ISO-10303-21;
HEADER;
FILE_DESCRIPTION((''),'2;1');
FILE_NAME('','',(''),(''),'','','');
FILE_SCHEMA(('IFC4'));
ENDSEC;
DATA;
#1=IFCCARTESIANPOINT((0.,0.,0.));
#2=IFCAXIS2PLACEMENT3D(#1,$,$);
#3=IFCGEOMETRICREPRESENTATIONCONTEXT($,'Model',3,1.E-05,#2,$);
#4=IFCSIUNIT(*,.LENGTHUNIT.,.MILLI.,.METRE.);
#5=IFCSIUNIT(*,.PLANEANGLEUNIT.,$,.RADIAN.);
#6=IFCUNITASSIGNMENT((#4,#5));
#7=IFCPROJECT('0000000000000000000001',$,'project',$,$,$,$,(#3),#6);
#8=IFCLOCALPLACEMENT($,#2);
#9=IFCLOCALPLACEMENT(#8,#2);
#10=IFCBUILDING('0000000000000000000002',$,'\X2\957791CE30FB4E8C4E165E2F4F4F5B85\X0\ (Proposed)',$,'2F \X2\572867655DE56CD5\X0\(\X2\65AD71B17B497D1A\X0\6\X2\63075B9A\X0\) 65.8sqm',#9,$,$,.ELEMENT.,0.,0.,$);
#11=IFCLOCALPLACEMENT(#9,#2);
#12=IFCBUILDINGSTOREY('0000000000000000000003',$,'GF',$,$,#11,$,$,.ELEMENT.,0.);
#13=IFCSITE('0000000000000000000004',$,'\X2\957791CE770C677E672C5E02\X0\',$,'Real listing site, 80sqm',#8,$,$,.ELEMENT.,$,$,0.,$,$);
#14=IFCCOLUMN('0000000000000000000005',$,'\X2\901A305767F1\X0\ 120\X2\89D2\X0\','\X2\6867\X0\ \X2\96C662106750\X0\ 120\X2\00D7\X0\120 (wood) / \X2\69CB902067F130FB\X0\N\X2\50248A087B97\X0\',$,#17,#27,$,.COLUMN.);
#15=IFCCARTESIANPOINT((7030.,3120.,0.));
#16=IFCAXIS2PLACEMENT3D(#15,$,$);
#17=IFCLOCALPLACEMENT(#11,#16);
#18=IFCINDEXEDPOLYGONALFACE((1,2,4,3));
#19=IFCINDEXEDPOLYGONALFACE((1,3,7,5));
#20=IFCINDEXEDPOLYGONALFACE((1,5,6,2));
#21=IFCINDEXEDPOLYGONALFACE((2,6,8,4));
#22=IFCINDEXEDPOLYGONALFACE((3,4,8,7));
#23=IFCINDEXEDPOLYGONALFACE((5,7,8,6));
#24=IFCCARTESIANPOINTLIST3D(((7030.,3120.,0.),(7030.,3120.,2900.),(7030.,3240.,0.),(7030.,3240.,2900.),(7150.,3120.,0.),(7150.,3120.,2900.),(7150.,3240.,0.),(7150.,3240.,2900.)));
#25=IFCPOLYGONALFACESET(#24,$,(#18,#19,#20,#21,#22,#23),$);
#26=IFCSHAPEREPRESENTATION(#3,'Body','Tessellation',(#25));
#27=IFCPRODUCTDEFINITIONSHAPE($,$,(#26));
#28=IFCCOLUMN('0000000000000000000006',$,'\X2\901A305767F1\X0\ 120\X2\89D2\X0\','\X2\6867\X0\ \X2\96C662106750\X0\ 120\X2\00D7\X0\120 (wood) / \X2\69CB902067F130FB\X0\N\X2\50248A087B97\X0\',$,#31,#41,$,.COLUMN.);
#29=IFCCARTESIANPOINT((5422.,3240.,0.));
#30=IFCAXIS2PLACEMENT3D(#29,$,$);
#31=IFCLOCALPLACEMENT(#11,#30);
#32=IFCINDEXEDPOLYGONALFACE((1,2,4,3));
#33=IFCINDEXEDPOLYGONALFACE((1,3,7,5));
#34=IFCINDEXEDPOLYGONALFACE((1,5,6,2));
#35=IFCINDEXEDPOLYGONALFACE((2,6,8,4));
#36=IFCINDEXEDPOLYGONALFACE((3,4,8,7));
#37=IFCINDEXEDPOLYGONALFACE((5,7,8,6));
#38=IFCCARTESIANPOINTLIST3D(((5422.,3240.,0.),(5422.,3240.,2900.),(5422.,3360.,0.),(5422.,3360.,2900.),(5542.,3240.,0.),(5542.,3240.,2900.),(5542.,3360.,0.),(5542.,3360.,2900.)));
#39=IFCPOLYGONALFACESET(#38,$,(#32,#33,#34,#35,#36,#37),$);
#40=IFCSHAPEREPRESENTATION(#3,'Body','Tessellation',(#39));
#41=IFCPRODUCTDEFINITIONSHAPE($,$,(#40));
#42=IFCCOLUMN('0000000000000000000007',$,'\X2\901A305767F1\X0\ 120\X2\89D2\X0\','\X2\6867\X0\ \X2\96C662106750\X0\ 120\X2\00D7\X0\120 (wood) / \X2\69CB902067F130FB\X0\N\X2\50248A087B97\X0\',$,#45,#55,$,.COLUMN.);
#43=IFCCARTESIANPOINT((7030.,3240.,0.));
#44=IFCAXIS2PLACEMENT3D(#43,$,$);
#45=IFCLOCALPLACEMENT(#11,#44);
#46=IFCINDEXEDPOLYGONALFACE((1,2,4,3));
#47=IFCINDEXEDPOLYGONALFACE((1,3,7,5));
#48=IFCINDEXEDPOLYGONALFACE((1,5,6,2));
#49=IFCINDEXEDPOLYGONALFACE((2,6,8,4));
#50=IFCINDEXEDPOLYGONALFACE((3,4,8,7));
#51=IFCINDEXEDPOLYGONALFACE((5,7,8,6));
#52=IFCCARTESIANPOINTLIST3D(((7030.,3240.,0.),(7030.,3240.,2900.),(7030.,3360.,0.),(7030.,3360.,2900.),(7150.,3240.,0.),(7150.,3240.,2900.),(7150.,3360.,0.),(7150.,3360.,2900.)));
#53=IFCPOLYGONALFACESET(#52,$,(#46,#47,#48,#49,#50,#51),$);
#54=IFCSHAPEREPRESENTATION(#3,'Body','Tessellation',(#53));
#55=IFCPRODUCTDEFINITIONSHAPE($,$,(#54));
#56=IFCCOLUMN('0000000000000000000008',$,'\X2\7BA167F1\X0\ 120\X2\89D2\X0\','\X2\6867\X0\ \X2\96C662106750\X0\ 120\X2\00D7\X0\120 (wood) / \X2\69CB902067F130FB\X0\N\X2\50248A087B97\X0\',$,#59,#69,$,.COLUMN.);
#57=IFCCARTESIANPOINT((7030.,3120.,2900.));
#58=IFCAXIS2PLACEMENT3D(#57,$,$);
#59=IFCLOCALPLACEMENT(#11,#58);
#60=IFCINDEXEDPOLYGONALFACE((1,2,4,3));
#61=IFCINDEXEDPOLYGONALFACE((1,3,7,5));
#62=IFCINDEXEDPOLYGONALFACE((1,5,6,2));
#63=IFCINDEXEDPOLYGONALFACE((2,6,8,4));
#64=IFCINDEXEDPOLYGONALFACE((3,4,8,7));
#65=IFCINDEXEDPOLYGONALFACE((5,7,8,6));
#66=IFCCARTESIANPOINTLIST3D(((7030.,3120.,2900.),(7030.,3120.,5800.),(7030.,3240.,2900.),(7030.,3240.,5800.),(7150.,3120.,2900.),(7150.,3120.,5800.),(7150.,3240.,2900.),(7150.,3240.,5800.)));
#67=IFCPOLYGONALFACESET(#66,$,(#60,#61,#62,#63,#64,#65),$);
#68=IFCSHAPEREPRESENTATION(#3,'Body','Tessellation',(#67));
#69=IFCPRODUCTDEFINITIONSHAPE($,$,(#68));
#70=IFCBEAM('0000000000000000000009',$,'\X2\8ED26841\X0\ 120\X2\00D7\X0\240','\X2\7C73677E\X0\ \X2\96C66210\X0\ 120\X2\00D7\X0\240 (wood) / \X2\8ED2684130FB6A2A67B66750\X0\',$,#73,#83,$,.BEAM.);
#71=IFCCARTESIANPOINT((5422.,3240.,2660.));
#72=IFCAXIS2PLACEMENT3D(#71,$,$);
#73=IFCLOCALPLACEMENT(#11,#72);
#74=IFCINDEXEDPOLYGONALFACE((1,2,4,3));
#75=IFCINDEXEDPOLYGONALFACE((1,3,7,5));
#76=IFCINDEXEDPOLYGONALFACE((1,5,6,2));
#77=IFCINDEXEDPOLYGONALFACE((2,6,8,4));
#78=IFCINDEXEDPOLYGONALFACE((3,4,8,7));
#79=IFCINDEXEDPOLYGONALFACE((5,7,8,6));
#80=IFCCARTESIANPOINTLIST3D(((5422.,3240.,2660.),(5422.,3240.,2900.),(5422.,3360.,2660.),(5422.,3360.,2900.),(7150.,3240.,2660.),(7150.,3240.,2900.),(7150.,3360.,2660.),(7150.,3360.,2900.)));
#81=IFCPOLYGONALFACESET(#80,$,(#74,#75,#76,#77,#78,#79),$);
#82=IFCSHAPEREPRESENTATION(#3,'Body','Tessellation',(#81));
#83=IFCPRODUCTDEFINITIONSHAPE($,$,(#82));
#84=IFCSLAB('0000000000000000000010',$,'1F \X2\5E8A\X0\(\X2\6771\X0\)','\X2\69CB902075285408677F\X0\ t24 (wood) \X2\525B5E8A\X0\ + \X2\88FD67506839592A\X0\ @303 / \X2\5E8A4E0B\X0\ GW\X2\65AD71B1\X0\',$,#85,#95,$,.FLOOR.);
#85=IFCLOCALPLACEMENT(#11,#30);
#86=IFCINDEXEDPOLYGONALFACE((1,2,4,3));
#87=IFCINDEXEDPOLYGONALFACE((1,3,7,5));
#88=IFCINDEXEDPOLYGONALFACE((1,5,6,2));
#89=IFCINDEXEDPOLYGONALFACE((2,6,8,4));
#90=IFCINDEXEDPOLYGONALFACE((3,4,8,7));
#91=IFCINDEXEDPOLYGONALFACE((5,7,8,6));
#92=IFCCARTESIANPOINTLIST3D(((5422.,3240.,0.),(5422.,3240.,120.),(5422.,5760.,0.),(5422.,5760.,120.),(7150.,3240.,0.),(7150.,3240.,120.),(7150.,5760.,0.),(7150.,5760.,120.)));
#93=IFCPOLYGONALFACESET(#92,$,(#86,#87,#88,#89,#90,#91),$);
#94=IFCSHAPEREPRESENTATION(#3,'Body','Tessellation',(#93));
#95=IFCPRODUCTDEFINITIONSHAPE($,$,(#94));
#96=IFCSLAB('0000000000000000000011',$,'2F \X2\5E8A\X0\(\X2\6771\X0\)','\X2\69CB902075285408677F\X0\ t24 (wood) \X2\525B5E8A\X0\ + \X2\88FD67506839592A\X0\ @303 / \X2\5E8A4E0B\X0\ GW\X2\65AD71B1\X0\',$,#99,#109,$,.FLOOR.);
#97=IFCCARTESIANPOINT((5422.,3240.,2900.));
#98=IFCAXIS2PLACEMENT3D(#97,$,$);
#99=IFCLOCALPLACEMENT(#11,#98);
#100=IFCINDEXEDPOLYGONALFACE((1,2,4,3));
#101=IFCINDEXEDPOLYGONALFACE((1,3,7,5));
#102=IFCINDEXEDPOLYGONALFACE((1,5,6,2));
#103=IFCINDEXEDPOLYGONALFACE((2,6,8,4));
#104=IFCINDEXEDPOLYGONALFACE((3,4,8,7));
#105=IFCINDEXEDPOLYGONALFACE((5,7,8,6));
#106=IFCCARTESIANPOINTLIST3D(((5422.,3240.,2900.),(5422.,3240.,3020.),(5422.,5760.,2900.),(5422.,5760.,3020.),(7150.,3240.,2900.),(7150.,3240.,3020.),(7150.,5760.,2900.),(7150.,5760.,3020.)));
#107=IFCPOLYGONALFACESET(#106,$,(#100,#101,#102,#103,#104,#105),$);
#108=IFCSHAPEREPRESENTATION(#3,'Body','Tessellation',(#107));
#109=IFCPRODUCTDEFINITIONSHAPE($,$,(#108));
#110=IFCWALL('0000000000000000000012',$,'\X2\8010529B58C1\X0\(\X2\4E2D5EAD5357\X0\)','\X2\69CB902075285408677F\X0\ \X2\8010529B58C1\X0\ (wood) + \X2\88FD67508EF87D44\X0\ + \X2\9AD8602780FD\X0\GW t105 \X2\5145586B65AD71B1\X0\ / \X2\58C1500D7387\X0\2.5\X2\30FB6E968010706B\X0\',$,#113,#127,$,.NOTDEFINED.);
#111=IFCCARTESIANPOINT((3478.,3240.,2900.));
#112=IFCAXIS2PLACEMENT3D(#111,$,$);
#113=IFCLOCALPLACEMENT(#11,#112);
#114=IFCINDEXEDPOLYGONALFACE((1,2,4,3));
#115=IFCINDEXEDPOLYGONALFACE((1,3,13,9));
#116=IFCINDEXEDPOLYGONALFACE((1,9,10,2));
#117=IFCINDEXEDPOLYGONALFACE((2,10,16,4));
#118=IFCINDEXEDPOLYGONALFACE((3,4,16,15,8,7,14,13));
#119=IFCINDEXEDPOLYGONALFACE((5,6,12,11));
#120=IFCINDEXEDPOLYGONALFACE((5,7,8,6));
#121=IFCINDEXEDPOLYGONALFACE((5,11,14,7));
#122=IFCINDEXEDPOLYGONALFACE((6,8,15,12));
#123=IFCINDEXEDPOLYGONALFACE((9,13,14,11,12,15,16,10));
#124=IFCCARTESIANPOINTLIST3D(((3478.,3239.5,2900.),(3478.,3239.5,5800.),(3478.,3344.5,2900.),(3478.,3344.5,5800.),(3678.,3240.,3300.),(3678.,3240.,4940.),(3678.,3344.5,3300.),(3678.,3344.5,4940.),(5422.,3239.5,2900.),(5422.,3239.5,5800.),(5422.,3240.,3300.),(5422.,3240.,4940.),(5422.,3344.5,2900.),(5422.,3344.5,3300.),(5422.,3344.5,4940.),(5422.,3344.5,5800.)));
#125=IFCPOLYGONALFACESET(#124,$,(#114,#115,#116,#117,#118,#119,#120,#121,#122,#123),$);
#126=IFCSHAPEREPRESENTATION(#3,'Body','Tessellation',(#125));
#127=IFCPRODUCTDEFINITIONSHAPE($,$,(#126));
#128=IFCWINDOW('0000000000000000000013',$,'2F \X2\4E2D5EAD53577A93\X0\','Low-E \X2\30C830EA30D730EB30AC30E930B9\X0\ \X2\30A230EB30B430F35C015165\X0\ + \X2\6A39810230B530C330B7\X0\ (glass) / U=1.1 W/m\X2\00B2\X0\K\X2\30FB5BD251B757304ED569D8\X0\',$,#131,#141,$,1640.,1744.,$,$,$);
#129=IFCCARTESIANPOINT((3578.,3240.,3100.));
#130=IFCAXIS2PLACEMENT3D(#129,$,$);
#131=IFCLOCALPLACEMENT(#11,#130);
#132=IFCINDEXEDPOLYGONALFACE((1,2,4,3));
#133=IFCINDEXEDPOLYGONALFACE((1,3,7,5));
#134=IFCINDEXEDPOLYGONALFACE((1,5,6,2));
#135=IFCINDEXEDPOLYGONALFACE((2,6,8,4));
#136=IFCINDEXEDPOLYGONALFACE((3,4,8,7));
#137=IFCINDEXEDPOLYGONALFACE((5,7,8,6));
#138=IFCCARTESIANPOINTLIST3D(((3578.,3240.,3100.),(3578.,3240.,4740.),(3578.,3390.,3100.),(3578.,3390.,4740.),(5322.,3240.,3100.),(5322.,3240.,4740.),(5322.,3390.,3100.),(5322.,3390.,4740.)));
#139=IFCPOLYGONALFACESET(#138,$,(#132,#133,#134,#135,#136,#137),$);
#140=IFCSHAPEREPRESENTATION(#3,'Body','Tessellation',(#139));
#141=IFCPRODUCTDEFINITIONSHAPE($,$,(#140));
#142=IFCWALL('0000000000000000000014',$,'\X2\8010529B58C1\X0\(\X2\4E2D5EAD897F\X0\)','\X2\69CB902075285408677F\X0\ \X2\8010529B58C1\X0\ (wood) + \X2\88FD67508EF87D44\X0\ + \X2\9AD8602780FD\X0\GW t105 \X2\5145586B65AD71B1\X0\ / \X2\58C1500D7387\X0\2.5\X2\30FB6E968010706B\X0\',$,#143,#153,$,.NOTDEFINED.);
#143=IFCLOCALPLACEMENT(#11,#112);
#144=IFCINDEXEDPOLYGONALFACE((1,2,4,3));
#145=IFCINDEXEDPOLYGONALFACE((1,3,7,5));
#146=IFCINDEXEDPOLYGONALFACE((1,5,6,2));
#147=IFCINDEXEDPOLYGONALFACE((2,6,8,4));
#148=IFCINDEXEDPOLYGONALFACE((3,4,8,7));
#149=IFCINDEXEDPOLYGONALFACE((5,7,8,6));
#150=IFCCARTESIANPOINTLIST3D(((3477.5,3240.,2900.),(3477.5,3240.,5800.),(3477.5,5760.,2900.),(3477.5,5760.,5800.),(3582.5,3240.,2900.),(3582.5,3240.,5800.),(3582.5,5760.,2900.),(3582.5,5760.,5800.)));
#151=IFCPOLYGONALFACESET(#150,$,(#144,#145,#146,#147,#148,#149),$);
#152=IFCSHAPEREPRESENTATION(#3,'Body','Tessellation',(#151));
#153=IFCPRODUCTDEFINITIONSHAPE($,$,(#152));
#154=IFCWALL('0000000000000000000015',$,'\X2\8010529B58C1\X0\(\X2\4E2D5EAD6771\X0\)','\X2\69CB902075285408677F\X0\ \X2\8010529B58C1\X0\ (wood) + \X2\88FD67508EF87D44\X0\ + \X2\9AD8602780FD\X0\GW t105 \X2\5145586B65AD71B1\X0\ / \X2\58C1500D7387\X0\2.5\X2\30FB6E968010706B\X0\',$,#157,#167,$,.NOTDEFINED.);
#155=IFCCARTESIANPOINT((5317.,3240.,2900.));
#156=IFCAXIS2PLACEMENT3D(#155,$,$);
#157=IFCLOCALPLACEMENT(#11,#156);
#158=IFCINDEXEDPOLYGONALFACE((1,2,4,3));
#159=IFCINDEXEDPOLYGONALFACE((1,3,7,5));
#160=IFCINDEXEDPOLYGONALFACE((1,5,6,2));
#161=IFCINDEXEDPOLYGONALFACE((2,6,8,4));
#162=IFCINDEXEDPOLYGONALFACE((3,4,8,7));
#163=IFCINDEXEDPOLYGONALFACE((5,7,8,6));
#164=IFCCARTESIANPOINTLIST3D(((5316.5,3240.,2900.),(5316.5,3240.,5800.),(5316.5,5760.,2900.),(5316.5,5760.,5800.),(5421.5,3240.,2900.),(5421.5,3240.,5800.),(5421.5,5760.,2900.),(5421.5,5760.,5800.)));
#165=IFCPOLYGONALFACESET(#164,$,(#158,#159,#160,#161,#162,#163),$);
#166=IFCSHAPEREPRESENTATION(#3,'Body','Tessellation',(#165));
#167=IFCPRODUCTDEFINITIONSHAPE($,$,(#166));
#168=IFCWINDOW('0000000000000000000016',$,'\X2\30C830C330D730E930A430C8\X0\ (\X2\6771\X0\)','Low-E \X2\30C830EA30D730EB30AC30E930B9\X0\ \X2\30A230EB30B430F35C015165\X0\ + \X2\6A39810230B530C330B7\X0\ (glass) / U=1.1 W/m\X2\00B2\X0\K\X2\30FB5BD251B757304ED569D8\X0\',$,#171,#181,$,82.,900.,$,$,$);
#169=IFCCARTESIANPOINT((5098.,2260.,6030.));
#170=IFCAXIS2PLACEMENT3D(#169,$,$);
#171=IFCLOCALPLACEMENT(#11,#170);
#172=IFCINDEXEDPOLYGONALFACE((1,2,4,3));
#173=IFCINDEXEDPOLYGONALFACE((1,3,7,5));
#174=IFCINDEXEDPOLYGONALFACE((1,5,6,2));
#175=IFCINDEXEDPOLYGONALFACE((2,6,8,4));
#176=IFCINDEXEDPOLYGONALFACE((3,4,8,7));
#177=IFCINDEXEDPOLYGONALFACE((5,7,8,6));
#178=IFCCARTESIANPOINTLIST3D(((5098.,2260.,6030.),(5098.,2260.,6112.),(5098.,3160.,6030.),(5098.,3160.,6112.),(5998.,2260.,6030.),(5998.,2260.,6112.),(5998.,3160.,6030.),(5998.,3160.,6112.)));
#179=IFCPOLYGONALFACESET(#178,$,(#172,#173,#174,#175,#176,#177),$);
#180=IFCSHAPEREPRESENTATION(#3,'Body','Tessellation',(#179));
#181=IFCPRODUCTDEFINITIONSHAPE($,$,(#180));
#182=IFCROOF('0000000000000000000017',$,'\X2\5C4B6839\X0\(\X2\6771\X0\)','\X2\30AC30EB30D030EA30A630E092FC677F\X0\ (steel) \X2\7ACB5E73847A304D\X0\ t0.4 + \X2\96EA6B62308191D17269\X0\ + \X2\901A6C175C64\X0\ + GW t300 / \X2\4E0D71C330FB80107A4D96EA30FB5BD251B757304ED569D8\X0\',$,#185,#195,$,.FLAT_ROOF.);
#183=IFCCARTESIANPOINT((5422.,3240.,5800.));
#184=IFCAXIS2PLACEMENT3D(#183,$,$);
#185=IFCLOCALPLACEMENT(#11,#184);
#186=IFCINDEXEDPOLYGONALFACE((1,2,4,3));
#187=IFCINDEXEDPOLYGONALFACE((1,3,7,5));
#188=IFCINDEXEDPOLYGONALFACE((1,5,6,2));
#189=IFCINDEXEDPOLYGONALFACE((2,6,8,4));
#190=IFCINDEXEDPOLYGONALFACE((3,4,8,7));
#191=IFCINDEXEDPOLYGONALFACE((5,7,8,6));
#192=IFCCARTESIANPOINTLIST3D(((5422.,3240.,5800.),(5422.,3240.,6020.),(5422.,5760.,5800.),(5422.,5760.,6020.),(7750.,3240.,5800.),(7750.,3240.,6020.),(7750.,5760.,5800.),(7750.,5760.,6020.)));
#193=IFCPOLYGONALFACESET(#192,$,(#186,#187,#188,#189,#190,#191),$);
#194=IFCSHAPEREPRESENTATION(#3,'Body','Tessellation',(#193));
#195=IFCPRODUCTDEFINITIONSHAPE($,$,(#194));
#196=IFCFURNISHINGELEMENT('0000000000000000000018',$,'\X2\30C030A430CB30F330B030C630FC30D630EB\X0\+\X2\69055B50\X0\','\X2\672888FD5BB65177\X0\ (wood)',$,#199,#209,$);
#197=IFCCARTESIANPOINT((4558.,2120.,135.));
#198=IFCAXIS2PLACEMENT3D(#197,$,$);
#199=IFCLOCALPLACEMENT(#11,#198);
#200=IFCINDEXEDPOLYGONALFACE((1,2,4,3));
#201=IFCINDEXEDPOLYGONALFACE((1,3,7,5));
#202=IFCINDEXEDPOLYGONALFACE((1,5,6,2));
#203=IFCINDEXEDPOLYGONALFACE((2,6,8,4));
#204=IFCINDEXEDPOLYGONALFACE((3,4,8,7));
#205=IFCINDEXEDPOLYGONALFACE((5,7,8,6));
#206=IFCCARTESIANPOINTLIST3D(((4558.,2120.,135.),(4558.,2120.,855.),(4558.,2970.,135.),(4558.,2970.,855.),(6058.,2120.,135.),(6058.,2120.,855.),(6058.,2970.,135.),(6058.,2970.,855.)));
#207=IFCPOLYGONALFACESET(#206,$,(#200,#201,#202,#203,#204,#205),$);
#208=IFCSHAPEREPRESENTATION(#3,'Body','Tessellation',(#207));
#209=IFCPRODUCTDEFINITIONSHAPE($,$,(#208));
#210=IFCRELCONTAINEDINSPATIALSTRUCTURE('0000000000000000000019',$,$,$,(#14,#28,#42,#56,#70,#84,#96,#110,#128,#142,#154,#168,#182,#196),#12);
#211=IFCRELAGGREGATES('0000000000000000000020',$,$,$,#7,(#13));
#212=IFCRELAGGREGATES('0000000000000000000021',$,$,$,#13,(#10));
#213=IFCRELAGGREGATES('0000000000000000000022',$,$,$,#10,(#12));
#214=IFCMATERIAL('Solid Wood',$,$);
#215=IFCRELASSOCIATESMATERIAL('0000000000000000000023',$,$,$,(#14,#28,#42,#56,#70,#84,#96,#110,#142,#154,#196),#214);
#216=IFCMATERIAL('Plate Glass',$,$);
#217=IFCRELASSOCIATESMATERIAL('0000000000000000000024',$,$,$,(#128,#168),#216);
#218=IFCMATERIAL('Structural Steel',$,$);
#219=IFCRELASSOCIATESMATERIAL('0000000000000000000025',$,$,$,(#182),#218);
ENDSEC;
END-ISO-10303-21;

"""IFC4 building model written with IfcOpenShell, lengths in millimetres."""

from ifc_helpers import new_model, si_unit, frame, frame_2d, origin, place, context, project, spatial, rectangle, extrude, material, element, fill, save


model = new_model("IFC4")

# Units and contexts
model_context = context("Model", 3, precision=1e-05, world=origin())
ifc_project = project(units=[si_unit("LENGTHUNIT", "METRE", prefix="MILLI"), si_unit("PLANEANGLEUNIT", "RADIAN")], contexts=[model_context])

# Site, building, storey
site_placement = place(None, origin())
site = spatial("IfcSite", under=ifc_project, at=site_placement, Name="長野県松本市", ObjectType="Real listing site, 80sqm", CompositionType="ELEMENT", RefElevation=0.0)
building_placement = place(site_placement, origin())
building = spatial("IfcBuilding", under=site, at=building_placement, Name="長野・二世帯住宅 (Proposed)", ObjectType="2F 在来工法(断熱等級6指定) 65.8sqm", CompositionType="ELEMENT", ElevationOfRefHeight=0.0, ElevationOfTerrain=0.0)
storey_placement = place(building_placement, origin())
storey = spatial("IfcBuildingStorey", under=building, at=storey_placement, Name="GF", CompositionType="ELEMENT", Elevation=0.0)

# Columns
ifc_material_1 = material(Name="Solid Wood")
column_1_placement = place(storey_placement, frame((7030.0, 3120.0, 0.0)))
element("IfcColumn", 1, at=column_1_placement, inside=storey, material=ifc_material_1, Name="通し柱 120角", Description="桧 集成材 120×120 (wood) / 構造柱・N値計算", PredefinedType="COLUMN", context=model_context, shape_type="SweptSolid", body=[
    extrude(rectangle(XDim=120.0, YDim=120.0, at=frame_2d((60.0, 60.0))), frame((7030.0, 3120.0, 0.0)), (0.0, 0.0, 1.0), 2900.0),
])
column_2_placement = place(storey_placement, frame((5422.0, 3240.0, 0.0)))
element("IfcColumn", 2, at=column_2_placement, inside=storey, material=ifc_material_1, Name="通し柱 120角", Description="桧 集成材 120×120 (wood) / 構造柱・N値計算", PredefinedType="COLUMN", context=model_context, shape_type="SweptSolid", body=[
    extrude(rectangle(XDim=120.0, YDim=120.0, at=frame_2d((60.0, 60.0))), frame((5422.0, 3240.0, 0.0)), (0.0, 0.0, 1.0), 2900.0),
])
column_3_placement = place(storey_placement, frame((7030.0, 3240.0, 0.0)))
element("IfcColumn", 3, at=column_3_placement, inside=storey, material=ifc_material_1, Name="通し柱 120角", Description="桧 集成材 120×120 (wood) / 構造柱・N値計算", PredefinedType="COLUMN", context=model_context, shape_type="SweptSolid", body=[
    extrude(rectangle(XDim=120.0, YDim=120.0, at=frame_2d((60.0, 60.0))), frame((7030.0, 3240.0, 0.0)), (0.0, 0.0, 1.0), 2900.0),
])
column_4_placement = place(storey_placement, frame((7030.0, 3120.0, 2900.0)))
element("IfcColumn", 4, at=column_4_placement, inside=storey, material=ifc_material_1, Name="管柱 120角", Description="桧 集成材 120×120 (wood) / 構造柱・N値計算", PredefinedType="COLUMN", context=model_context, shape_type="SweptSolid", body=[
    extrude(rectangle(XDim=120.0, YDim=120.0, at=frame_2d((60.0, 60.0))), frame((7030.0, 3120.0, 2900.0)), (0.0, 0.0, 1.0), 2900.0),
])

# Beam
beam_1_placement = place(storey_placement, frame((5422.0, 3240.0, 2660.0)))
element("IfcBeam", 5, at=beam_1_placement, inside=storey, material=ifc_material_1, Name="軒桁 120×240", Description="米松 集成 120×240 (wood) / 軒桁・横架材", PredefinedType="BEAM", context=model_context, shape_type="SweptSolid", body=[
    extrude(rectangle(XDim=1728.0, YDim=120.0, at=frame_2d((864.0, 60.0))), frame((5422.0, 3240.0, 2660.0)), (0.0, 0.0, 1.0), 240.0),
])

# Slabs
slab_1_placement = place(storey_placement, frame((5422.0, 3240.0, 0.0)))
element("IfcSlab", 6, at=slab_1_placement, inside=storey, material=ifc_material_1, Name="1F 床(東)", Description="構造用合板 t24 (wood) 剛床 + 製材根太 @303 / 床下 GW断熱", PredefinedType="FLOOR", context=model_context, shape_type="SweptSolid", body=[
    extrude(rectangle(XDim=1728.0, YDim=2520.0, at=frame_2d((864.0, 1260.0))), frame((5422.0, 3240.0, 0.0)), (0.0, 0.0, 1.0), 120.0),
])
slab_2_placement = place(storey_placement, frame((5422.0, 3240.0, 2900.0)))
element("IfcSlab", 7, at=slab_2_placement, inside=storey, material=ifc_material_1, Name="2F 床(東)", Description="構造用合板 t24 (wood) 剛床 + 製材根太 @303 / 床下 GW断熱", PredefinedType="FLOOR", context=model_context, shape_type="SweptSolid", body=[
    extrude(rectangle(XDim=1728.0, YDim=2520.0, at=frame_2d((864.0, 1260.0))), frame((5422.0, 3240.0, 2900.0)), (0.0, 0.0, 1.0), 120.0),
])

# Wall, opening, window
wall_1_placement = place(storey_placement, frame((3478.0, 3240.0, 2900.0)))
wall_1 = element("IfcWall", 8, at=wall_1_placement, inside=storey, material=ifc_material_1, Name="耐力壁(中庭南)", Description="構造用合板 耐力壁 (wood) + 製材軸組 + 高性能GW t105 充填断熱 / 壁倍率2.5・準耐火", PredefinedType="NOTDEFINED", context=model_context, shape_type="SweptSolid", body=[
    extrude(rectangle(XDim=1944.0, YDim=105.0, at=frame_2d((972.0, 52.0))), frame((3478.0, 3240.0, 2900.0)), (0.0, 0.0, 1.0), 2900.0),
])
opening_placement = place(storey_placement, frame((3578.0, 3240.0, 3100.0)))
opening = element("IfcOpeningElement", 9, at=opening_placement, cuts=wall_1, PredefinedType="NOTDEFINED", context=model_context, shape_type="SweptSolid", body=[
    extrude(rectangle(XDim=1744.0, YDim=150.0, at=frame_2d((872.0, 75.0))), frame((3578.0, 3240.0, 3100.0)), (0.0, 0.0, 1.0), 1640.0),
])
ifc_material_2 = material(Name="Plate Glass")
window_1_placement = place(storey_placement, frame((3578.0, 3240.0, 3100.0)))
window_1 = element("IfcWindow", 10, at=window_1_placement, inside=storey, material=ifc_material_2, Name="2F 中庭南窓", Description="Low-E トリプルガラス アルゴン封入 + 樹脂サッシ (glass) / U=1.1 W/m²K・寒冷地仕様", OverallHeight=1640.0, OverallWidth=1744.0, context=model_context, shape_type="SweptSolid", body=[
    extrude(rectangle(XDim=1744.0, YDim=150.0, at=frame_2d((872.0, 75.0))), frame((3578.0, 3240.0, 3100.0)), (0.0, 0.0, 1.0), 1640.0),
])
fill(opening, window_1)

# Walls
wall_2_placement = place(storey_placement, frame((3478.0, 3240.0, 2900.0)))
element("IfcWall", 11, at=wall_2_placement, inside=storey, material=ifc_material_1, Name="耐力壁(中庭西)", Description="構造用合板 耐力壁 (wood) + 製材軸組 + 高性能GW t105 充填断熱 / 壁倍率2.5・準耐火", PredefinedType="NOTDEFINED", context=model_context, shape_type="SweptSolid", body=[
    extrude(rectangle(XDim=105.0, YDim=2520.0, at=frame_2d((52.0, 1260.0))), frame((3478.0, 3240.0, 2900.0)), (0.0, 0.0, 1.0), 2900.0),
])
wall_3_placement = place(storey_placement, frame((5317.0, 3240.0, 2900.0)))
element("IfcWall", 12, at=wall_3_placement, inside=storey, material=ifc_material_1, Name="耐力壁(中庭東)", Description="構造用合板 耐力壁 (wood) + 製材軸組 + 高性能GW t105 充填断熱 / 壁倍率2.5・準耐火", PredefinedType="NOTDEFINED", context=model_context, shape_type="SweptSolid", body=[
    extrude(rectangle(XDim=105.0, YDim=2520.0, at=frame_2d((52.0, 1260.0))), frame((5317.0, 3240.0, 2900.0)), (0.0, 0.0, 1.0), 2900.0),
])

# Window
window_2_placement = place(storey_placement, frame((5098.0, 2260.0, 6030.0)))
element("IfcWindow", 13, at=window_2_placement, inside=storey, material=ifc_material_2, Name="トップライト (東)", Description="Low-E トリプルガラス アルゴン封入 + 樹脂サッシ (glass) / U=1.1 W/m²K・寒冷地仕様", OverallHeight=82.0, OverallWidth=900.0, context=model_context, shape_type="SweptSolid", body=[
    extrude(rectangle(XDim=900.0, YDim=900.0, at=frame_2d((450.0, 450.0))), frame((5098.0, 2260.0, 6030.0)), (0.0, 0.0, 1.0), 82.0),
])

# Roof
ifc_material_3 = material(Name="Structural Steel")
for number, where, name in (
    (14, (5422.0, 3240.0, 5800.0), "屋根(東)"),
):
    element("IfcRoof", number, at=place(storey_placement, frame(where)), inside=storey, material=ifc_material_3, Name=name, Description="ガルバリウム鋼板 (steel) 立平葺き t0.4 + 雪止め金物 + 通気層 + GW t300 / 不燃・耐積雪・寒冷地仕様", PredefinedType="FLAT_ROOF", context=model_context, shape_type="SweptSolid", body=[
        extrude(rectangle(XDim=2328.0, YDim=2520.0, at=frame_2d((1164.0, 1260.0))), frame((5422.0, 3240.0, 5800.0)), (0.0, 0.0, 1.0), 220.0),
    ])

# Furnishing element
furnishing_1_placement = place(storey_placement, frame((4558.0, 2120.0, 135.0)))
element("IfcFurnishingElement", 15, at=furnishing_1_placement, inside=storey, material=ifc_material_1, Name="ダイニングテーブル+椅子", Description="木製家具 (wood)", context=model_context, shape_type="SweptSolid", body=[
    extrude(rectangle(XDim=1500.0, YDim=850.0, at=frame_2d((750.0, 425.0))), frame((4558.0, 2120.0, 135.0)), (0.0, 0.0, 1.0), 720.0),
])

save(model, "model.ifc")
